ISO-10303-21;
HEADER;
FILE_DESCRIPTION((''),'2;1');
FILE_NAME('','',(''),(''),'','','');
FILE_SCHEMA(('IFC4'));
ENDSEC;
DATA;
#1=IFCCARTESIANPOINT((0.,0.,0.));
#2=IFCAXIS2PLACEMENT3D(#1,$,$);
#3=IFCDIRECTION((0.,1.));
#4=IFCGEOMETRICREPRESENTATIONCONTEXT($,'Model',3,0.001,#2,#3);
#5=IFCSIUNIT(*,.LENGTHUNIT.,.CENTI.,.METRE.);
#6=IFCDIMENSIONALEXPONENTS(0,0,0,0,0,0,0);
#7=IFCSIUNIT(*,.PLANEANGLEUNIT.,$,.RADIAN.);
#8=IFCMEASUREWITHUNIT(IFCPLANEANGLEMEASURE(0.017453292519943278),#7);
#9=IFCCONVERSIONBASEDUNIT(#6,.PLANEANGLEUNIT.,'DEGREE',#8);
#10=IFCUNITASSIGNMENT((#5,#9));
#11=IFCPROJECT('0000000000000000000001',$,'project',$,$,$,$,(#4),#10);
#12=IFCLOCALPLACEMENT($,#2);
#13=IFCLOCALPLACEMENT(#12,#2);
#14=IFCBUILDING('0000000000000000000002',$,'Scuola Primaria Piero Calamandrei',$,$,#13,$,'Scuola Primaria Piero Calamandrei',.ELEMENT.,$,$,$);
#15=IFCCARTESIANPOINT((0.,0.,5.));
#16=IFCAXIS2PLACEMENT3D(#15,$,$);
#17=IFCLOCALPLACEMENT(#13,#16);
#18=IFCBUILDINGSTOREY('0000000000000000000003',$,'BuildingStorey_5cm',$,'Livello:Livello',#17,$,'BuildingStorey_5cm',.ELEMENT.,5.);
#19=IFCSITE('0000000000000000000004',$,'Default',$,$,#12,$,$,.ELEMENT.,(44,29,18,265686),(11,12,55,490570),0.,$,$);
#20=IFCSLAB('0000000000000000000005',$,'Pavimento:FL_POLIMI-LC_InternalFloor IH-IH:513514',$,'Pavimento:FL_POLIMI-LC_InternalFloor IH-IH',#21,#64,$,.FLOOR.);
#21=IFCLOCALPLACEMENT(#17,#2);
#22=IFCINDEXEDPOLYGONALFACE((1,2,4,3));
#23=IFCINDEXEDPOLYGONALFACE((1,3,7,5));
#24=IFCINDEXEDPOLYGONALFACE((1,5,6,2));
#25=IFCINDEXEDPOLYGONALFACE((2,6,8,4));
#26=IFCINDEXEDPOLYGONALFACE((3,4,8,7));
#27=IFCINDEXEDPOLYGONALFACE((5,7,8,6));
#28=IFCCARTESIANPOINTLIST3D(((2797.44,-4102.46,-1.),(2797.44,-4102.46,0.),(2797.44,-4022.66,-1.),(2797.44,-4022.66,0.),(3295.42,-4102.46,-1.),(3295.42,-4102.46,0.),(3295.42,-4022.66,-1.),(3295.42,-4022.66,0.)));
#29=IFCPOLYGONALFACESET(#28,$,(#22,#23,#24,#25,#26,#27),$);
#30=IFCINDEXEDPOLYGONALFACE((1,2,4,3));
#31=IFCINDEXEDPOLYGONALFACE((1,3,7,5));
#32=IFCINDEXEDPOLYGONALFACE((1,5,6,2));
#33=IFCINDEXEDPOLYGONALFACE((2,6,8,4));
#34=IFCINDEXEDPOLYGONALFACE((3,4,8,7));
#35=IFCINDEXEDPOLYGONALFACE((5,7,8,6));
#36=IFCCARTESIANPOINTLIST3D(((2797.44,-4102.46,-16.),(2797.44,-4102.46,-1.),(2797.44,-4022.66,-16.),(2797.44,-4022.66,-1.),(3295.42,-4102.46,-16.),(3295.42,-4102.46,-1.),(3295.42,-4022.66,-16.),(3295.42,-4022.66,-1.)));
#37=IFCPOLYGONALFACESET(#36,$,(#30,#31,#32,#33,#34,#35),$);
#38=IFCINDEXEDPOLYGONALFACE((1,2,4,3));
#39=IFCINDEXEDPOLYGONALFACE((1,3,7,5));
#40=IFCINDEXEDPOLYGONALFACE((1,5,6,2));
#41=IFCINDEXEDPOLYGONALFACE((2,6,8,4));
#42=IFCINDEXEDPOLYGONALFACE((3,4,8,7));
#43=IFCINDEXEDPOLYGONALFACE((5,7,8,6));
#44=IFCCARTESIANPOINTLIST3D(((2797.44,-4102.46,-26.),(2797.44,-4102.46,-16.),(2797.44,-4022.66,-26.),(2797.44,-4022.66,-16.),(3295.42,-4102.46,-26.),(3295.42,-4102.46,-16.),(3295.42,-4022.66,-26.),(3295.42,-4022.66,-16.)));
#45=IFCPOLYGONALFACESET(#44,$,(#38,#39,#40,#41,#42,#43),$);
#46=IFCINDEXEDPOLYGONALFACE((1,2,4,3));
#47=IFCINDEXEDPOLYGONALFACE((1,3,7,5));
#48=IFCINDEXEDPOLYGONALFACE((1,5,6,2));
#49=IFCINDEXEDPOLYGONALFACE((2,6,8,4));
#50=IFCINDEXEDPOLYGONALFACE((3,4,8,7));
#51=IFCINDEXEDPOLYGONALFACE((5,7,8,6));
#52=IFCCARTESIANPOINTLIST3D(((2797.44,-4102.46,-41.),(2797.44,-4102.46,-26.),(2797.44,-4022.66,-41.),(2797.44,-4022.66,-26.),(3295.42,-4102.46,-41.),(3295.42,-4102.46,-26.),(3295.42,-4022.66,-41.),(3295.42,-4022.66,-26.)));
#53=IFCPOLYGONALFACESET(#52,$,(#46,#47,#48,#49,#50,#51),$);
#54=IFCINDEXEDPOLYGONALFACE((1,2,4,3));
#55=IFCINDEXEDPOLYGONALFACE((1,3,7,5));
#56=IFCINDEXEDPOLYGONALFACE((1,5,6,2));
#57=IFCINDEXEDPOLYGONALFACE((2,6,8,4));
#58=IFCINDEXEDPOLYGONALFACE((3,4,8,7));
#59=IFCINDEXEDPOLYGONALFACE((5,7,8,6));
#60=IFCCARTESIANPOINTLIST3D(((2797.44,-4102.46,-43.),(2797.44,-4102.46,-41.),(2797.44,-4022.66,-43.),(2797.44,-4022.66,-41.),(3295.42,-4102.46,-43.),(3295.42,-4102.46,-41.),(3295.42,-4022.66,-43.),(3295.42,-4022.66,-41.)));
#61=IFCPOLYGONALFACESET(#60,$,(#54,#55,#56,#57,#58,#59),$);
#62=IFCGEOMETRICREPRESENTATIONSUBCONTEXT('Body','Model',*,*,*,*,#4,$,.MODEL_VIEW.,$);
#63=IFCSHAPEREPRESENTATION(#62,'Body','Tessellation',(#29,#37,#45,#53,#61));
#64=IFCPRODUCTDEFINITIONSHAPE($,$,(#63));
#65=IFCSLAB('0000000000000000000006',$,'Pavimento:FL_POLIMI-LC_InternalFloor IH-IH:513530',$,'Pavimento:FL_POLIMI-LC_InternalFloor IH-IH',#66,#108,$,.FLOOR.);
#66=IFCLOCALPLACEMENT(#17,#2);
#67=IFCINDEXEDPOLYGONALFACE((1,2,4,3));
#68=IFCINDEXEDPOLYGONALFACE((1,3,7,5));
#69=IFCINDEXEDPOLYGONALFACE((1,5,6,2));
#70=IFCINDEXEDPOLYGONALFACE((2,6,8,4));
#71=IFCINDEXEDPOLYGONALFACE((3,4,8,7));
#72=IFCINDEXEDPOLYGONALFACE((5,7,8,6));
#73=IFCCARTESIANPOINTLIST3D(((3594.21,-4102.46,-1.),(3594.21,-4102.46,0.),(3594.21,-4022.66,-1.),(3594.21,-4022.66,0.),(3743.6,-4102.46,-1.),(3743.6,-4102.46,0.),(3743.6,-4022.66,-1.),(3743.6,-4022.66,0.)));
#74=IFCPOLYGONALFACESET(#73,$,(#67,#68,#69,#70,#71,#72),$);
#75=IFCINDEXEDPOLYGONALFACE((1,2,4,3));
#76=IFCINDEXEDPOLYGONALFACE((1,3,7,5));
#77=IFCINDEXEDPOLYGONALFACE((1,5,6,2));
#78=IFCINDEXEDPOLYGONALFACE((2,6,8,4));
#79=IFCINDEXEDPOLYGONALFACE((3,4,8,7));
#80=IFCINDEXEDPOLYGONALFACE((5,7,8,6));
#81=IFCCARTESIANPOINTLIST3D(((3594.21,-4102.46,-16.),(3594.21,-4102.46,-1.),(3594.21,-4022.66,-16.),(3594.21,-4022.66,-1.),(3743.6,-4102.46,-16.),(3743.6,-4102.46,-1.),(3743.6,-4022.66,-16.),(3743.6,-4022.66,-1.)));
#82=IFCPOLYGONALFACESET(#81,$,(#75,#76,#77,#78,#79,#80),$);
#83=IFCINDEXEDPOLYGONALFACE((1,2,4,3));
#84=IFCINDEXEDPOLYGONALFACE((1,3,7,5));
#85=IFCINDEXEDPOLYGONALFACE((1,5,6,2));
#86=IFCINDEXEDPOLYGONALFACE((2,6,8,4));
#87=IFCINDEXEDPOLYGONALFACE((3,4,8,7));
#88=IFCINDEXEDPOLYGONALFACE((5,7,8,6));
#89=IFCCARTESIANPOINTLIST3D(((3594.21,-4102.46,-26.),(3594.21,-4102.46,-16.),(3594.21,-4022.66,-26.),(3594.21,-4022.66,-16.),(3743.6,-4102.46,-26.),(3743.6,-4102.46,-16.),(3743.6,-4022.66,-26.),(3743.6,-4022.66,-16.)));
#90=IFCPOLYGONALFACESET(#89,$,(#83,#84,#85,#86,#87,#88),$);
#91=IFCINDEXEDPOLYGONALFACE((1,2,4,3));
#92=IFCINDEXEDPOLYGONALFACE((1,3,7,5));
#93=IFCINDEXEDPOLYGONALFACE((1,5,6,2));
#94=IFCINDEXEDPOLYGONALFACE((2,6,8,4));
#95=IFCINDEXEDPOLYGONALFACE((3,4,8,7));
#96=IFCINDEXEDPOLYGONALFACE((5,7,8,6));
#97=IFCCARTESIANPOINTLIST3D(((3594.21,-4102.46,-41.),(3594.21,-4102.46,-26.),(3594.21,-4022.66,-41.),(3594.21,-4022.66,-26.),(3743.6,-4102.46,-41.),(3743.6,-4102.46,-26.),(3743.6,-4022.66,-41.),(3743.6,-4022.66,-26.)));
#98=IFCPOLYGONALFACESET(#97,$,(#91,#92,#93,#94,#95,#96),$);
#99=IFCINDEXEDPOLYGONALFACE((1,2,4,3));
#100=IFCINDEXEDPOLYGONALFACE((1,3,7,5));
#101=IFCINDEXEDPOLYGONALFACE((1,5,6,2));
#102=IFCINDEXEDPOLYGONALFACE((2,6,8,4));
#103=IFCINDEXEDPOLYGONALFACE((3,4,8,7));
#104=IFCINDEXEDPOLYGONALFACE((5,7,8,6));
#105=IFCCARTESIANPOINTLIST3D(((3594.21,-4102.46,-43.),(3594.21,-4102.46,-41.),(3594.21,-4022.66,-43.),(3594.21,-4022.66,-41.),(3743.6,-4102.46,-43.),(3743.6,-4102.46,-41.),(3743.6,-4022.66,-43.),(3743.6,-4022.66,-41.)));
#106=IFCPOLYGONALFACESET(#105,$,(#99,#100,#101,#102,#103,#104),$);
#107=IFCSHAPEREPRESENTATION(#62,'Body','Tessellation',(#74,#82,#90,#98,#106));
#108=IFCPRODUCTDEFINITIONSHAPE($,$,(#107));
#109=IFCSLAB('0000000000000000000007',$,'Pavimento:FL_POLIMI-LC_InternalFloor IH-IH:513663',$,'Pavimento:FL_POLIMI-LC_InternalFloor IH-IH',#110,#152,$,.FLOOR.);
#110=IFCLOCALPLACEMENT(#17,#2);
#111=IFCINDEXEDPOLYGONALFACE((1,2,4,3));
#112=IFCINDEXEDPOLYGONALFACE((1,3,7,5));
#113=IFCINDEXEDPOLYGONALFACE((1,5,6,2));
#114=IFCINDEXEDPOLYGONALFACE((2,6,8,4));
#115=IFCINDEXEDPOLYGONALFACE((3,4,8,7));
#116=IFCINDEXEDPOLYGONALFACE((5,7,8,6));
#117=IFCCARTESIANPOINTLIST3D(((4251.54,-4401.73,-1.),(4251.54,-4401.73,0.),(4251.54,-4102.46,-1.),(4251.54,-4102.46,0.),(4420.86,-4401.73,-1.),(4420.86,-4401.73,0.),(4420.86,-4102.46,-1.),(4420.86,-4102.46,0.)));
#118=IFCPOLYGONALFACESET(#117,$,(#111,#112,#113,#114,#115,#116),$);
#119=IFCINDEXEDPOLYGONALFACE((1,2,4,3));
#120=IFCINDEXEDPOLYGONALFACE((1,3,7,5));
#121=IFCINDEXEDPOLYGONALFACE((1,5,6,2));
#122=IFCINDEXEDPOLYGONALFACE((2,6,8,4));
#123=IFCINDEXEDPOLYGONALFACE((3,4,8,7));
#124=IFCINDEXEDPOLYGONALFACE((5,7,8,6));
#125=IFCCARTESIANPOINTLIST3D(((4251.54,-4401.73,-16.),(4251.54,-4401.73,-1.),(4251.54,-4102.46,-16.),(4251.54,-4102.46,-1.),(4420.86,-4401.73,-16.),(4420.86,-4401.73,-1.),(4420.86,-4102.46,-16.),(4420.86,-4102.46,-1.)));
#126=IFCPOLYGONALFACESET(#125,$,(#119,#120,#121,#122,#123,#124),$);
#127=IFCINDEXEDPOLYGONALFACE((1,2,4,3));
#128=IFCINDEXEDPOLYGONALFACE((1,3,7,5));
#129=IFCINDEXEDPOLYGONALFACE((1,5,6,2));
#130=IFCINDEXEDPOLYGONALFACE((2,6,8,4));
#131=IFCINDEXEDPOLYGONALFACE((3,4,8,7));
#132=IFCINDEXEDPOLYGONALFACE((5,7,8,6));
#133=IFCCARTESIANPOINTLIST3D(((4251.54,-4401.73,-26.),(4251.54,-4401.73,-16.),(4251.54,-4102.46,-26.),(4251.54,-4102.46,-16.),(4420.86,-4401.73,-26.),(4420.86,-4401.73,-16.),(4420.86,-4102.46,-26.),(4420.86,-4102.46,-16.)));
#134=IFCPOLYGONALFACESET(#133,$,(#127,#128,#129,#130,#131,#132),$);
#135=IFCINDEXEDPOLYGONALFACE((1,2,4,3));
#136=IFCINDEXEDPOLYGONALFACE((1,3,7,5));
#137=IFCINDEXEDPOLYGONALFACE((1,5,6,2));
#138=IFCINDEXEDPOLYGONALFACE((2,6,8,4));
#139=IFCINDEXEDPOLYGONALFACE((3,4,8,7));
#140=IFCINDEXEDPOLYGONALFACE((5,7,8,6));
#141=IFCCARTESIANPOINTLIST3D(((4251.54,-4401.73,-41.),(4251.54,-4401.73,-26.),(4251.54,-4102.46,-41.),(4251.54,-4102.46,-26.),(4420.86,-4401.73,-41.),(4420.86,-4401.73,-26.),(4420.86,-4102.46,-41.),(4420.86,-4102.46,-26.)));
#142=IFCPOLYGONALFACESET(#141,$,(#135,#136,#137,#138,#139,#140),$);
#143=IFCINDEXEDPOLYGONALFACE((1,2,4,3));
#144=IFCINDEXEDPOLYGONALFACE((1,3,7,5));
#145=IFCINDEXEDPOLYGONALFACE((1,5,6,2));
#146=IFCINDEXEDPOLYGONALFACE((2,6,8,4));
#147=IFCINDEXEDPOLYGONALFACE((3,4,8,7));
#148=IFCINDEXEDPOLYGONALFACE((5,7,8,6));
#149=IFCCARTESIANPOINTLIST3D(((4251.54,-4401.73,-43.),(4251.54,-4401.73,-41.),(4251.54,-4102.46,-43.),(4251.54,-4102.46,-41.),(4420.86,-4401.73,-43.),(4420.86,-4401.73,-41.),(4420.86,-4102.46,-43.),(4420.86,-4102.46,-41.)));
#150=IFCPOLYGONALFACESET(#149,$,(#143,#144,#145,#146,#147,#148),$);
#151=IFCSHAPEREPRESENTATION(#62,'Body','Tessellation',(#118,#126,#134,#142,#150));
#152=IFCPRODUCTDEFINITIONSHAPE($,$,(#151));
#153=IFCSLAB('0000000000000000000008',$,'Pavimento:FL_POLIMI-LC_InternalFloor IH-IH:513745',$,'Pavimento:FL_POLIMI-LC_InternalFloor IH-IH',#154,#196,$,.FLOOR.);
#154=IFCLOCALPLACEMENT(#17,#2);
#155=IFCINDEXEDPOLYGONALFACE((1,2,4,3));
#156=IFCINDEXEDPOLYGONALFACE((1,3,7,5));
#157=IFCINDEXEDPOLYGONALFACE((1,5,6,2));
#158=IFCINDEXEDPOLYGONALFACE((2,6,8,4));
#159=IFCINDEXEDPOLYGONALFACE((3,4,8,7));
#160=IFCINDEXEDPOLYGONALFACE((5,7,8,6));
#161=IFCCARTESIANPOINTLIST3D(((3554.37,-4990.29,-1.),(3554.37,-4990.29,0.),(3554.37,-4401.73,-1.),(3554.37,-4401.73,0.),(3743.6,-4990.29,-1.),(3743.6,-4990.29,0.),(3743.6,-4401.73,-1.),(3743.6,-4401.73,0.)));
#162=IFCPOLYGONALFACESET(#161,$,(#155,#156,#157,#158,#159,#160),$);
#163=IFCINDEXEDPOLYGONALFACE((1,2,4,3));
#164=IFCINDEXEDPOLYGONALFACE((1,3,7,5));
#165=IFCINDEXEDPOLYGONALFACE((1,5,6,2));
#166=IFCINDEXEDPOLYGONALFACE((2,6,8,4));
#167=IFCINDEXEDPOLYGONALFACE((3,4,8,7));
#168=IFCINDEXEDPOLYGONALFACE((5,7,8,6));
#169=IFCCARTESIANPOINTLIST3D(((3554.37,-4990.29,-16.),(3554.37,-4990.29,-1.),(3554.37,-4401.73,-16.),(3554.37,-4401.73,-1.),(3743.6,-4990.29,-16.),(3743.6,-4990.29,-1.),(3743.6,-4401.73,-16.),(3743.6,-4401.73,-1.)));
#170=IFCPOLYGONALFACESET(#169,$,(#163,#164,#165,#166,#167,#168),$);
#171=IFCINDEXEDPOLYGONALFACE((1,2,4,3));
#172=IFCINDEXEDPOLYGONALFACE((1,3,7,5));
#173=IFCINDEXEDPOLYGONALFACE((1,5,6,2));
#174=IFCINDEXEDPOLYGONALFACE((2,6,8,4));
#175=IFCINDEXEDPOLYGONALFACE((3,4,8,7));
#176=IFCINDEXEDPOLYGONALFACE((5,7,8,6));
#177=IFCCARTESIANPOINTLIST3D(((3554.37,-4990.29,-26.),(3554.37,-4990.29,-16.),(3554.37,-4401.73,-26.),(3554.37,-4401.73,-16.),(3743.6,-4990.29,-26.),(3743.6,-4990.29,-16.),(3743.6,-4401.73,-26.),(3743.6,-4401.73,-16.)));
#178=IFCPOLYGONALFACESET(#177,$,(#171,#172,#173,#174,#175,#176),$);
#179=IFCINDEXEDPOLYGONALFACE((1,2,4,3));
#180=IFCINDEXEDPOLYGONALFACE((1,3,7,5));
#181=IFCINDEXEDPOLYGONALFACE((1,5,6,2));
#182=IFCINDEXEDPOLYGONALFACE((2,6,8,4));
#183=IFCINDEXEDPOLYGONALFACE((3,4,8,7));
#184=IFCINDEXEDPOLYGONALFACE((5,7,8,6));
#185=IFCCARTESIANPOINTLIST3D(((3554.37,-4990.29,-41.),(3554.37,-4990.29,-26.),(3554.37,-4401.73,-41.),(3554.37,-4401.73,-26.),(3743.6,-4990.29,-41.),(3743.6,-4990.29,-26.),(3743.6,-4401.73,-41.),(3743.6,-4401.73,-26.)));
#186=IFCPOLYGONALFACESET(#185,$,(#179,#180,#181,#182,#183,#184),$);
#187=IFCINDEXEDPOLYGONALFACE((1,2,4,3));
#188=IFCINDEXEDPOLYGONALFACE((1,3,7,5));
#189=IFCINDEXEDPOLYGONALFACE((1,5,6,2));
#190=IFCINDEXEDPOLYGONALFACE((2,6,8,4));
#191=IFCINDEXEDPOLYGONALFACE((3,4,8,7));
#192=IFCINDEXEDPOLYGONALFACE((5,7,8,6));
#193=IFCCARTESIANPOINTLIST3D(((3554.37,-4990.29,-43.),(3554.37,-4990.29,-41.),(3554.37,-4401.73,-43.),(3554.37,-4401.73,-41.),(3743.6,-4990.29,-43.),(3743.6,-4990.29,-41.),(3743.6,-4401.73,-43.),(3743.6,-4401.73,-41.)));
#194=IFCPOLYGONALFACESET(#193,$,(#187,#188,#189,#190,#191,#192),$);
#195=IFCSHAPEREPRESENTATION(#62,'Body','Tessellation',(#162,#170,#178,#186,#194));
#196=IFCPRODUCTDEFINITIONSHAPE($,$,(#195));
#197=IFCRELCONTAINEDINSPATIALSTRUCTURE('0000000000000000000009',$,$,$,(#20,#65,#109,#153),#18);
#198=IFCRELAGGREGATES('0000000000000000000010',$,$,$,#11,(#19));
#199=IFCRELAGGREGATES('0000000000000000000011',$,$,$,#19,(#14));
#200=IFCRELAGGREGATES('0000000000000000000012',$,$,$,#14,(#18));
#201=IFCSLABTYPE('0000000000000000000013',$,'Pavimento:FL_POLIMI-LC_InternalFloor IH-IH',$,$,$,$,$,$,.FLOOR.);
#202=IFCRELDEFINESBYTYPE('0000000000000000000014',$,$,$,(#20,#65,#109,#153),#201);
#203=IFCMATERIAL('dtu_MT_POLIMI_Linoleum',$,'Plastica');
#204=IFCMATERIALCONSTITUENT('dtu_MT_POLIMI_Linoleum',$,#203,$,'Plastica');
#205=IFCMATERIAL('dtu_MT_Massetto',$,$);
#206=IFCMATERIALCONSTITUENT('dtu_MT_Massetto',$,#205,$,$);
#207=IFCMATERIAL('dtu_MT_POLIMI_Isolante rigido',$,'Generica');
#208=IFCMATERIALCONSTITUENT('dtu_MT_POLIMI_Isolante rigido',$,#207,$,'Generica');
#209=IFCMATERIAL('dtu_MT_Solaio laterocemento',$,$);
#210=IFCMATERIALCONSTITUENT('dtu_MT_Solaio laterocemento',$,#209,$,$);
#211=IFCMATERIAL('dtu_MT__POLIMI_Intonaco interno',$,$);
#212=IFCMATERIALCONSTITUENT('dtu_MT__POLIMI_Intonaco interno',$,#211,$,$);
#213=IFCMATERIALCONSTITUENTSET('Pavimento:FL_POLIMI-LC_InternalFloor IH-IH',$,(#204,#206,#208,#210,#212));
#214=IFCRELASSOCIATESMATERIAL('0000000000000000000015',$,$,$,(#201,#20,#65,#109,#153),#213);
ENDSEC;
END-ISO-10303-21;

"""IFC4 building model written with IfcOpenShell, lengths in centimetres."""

from ifc_helpers import new_model, entity, si_unit, converted_unit, direction, frame, origin, place, context, subcontext, project, spatial, indexed_curve, outline, extrude, material, constituent, constituent_set, type_object, element, save


model = new_model("IFC4")

# Units and contexts
model_context = context("Model", 3, precision=0.001, world=origin(), true_north=direction((0.0, 1.0)))
body_context = subcontext(model_context, "Body", "Model", "MODEL_VIEW")
ifc_project = project(units=[si_unit("LENGTHUNIT", "METRE", prefix="CENTI"), converted_unit("PLANEANGLEUNIT", "DEGREE", entity("IfcPlaneAngleMeasure", 0.017453292519943278), si_unit("PLANEANGLEUNIT", "RADIAN"), dimensions=[0, 0, 0, 0, 0, 0, 0])], contexts=[model_context])

# Site, building, storey
site_placement = place(None, origin())
site = spatial("IfcSite", under=ifc_project, at=site_placement, Name="Default", CompositionType="ELEMENT", RefLatitude=(44, 29, 18, 265686), RefLongitude=(11, 12, 55, 490570), RefElevation=0.0)
building_placement = place(site_placement, origin())
building = spatial("IfcBuilding", under=site, at=building_placement, Name="Scuola Primaria Piero Calamandrei", LongName="Scuola Primaria Piero Calamandrei", CompositionType="ELEMENT")
storey_placement = place(building_placement, frame((0.0, 0.0, 5.0)))
storey = spatial("IfcBuildingStorey", under=building, at=storey_placement, Name="BuildingStorey_5cm", ObjectType="Livello:Livello", LongName="BuildingStorey_5cm", CompositionType="ELEMENT", Elevation=5.0)

# Slabs
ifc_material_1 = material(Name="dtu_MT_POLIMI_Linoleum", Category="Plastica")
ifc_constituent_1 = constituent(ifc_material_1, Name="dtu_MT_POLIMI_Linoleum", Category="Plastica")
ifc_material_2 = material(Name="dtu_MT_Massetto")
ifc_constituent_2 = constituent(ifc_material_2, Name="dtu_MT_Massetto")
ifc_material_3 = material(Name="dtu_MT_POLIMI_Isolante rigido", Category="Generica")
ifc_constituent_3 = constituent(ifc_material_3, Name="dtu_MT_POLIMI_Isolante rigido", Category="Generica")
ifc_material_4 = material(Name="dtu_MT_Solaio laterocemento")
ifc_constituent_4 = constituent(ifc_material_4, Name="dtu_MT_Solaio laterocemento")
ifc_material_5 = material(Name="dtu_MT__POLIMI_Intonaco interno")
ifc_constituent_5 = constituent(ifc_material_5, Name="dtu_MT__POLIMI_Intonaco interno")
ifc_constituent_set_1 = constituent_set(constituents=[ifc_constituent_1, ifc_constituent_2, ifc_constituent_3, ifc_constituent_4, ifc_constituent_5], Name="Pavimento:FL_POLIMI-LC_InternalFloor IH-IH")
slab_type_1 = type_object("IfcSlabType", Name="Pavimento:FL_POLIMI-LC_InternalFloor IH-IH", PredefinedType="FLOOR", material=ifc_constituent_set_1)
slab_1_placement = place(storey_placement, origin())
element("IfcSlab", 1, at=slab_1_placement, inside=storey, type_object=slab_type_1, material=ifc_constituent_set_1, Name="Pavimento:FL_POLIMI-LC_InternalFloor IH-IH:513514", ObjectType="Pavimento:FL_POLIMI-LC_InternalFloor IH-IH", PredefinedType="FLOOR", context=body_context, shape_type="SweptSolid", body=[
    extrude(outline(indexed_curve([(-39.9, -248.99), (39.9, -248.99), (39.9, 248.99), (-39.9, 248.99), (-39.9, -248.99)], self_intersect=False)), frame((3046.43, -4062.56, -1.0), z_axis=(0.0, 0.0, 1.0), x_axis=(0.0, 1.0, 0.0)), (0.0, 0.0, 1.0), 1.0),
    extrude(outline(indexed_curve([(-39.9, -248.99), (39.9, -248.99), (39.9, 248.99), (-39.9, 248.99), (-39.9, -248.99)], self_intersect=False)), frame((3046.43, -4062.56, -16.0), z_axis=(0.0, 0.0, 1.0), x_axis=(0.0, 1.0, 0.0)), (0.0, 0.0, 1.0), 15.0),
    extrude(outline(indexed_curve([(-39.9, -248.99), (39.9, -248.99), (39.9, 248.99), (-39.9, 248.99), (-39.9, -248.99)], self_intersect=False)), frame((3046.43, -4062.56, -26.0), z_axis=(0.0, 0.0, 1.0), x_axis=(0.0, 1.0, 0.0)), (0.0, 0.0, 1.0), 10.0),
    extrude(outline(indexed_curve([(-39.9, -248.99), (39.9, -248.99), (39.9, 248.99), (-39.9, 248.99), (-39.9, -248.99)], self_intersect=False)), frame((3046.43, -4062.56, -41.0), z_axis=(0.0, 0.0, 1.0), x_axis=(0.0, 1.0, 0.0)), (0.0, 0.0, 1.0), 15.0),
    extrude(outline(indexed_curve([(-39.9, -248.99), (39.9, -248.99), (39.9, 248.99), (-39.9, 248.99), (-39.9, -248.99)], self_intersect=False)), frame((3046.43, -4062.56, -43.0), z_axis=(0.0, 0.0, 1.0), x_axis=(0.0, 1.0, 0.0)), (0.0, 0.0, 1.0), 2.0),
])
slab_2_placement = place(storey_placement, origin())
element("IfcSlab", 2, at=slab_2_placement, inside=storey, type_object=slab_type_1, material=ifc_constituent_set_1, Name="Pavimento:FL_POLIMI-LC_InternalFloor IH-IH:513530", ObjectType="Pavimento:FL_POLIMI-LC_InternalFloor IH-IH", PredefinedType="FLOOR", context=body_context, shape_type="SweptSolid", body=[
    extrude(outline(indexed_curve([(-39.9, -74.7), (39.9, -74.7), (39.9, 74.7), (-39.9, 74.7), (-39.9, -74.7)], self_intersect=False)), frame((3668.9, -4062.56, -1.0), z_axis=(0.0, 0.0, 1.0), x_axis=(0.0, 1.0, 0.0)), (0.0, 0.0, 1.0), 1.0),
    extrude(outline(indexed_curve([(-39.9, -74.7), (39.9, -74.7), (39.9, 74.7), (-39.9, 74.7), (-39.9, -74.7)], self_intersect=False)), frame((3668.9, -4062.56, -16.0), z_axis=(0.0, 0.0, 1.0), x_axis=(0.0, 1.0, 0.0)), (0.0, 0.0, 1.0), 15.0),
    extrude(outline(indexed_curve([(-39.9, -74.7), (39.9, -74.7), (39.9, 74.7), (-39.9, 74.7), (-39.9, -74.7)], self_intersect=False)), frame((3668.9, -4062.56, -26.0), z_axis=(0.0, 0.0, 1.0), x_axis=(0.0, 1.0, 0.0)), (0.0, 0.0, 1.0), 10.0),
    extrude(outline(indexed_curve([(-39.9, -74.7), (39.9, -74.7), (39.9, 74.7), (-39.9, 74.7), (-39.9, -74.7)], self_intersect=False)), frame((3668.9, -4062.56, -41.0), z_axis=(0.0, 0.0, 1.0), x_axis=(0.0, 1.0, 0.0)), (0.0, 0.0, 1.0), 15.0),
    extrude(outline(indexed_curve([(-39.9, -74.7), (39.9, -74.7), (39.9, 74.7), (-39.9, 74.7), (-39.9, -74.7)], self_intersect=False)), frame((3668.9, -4062.56, -43.0), z_axis=(0.0, 0.0, 1.0), x_axis=(0.0, 1.0, 0.0)), (0.0, 0.0, 1.0), 2.0),
])
slab_3_placement = place(storey_placement, origin())
element("IfcSlab", 3, at=slab_3_placement, inside=storey, type_object=slab_type_1, material=ifc_constituent_set_1, Name="Pavimento:FL_POLIMI-LC_InternalFloor IH-IH:513663", ObjectType="Pavimento:FL_POLIMI-LC_InternalFloor IH-IH", PredefinedType="FLOOR", context=body_context, shape_type="SweptSolid", body=[
    extrude(outline(indexed_curve([(-84.66, -149.63), (84.66, -149.63), (84.66, 149.63), (-84.66, 149.63), (-84.66, -149.63)], self_intersect=False)), frame((4336.2, -4252.1, -1.0), z_axis=(0.0, 0.0, 1.0), x_axis=(-1.0, 0.0, 0.0)), (0.0, 0.0, 1.0), 1.0),
    extrude(outline(indexed_curve([(-84.66, -149.63), (84.66, -149.63), (84.66, 149.63), (-84.66, 149.63), (-84.66, -149.63)], self_intersect=False)), frame((4336.2, -4252.1, -16.0), z_axis=(0.0, 0.0, 1.0), x_axis=(-1.0, 0.0, 0.0)), (0.0, 0.0, 1.0), 15.0),
    extrude(outline(indexed_curve([(-84.66, -149.63), (84.66, -149.63), (84.66, 149.63), (-84.66, 149.63), (-84.66, -149.63)], self_intersect=False)), frame((4336.2, -4252.1, -26.0), z_axis=(0.0, 0.0, 1.0), x_axis=(-1.0, 0.0, 0.0)), (0.0, 0.0, 1.0), 10.0),
    extrude(outline(indexed_curve([(-84.66, -149.63), (84.66, -149.63), (84.66, 149.63), (-84.66, 149.63), (-84.66, -149.63)], self_intersect=False)), frame((4336.2, -4252.1, -41.0), z_axis=(0.0, 0.0, 1.0), x_axis=(-1.0, 0.0, 0.0)), (0.0, 0.0, 1.0), 15.0),
    extrude(outline(indexed_curve([(-84.66, -149.63), (84.66, -149.63), (84.66, 149.63), (-84.66, 149.63), (-84.66, -149.63)], self_intersect=False)), frame((4336.2, -4252.1, -43.0), z_axis=(0.0, 0.0, 1.0), x_axis=(-1.0, 0.0, 0.0)), (0.0, 0.0, 1.0), 2.0),
])
slab_4_placement = place(storey_placement, origin())
element("IfcSlab", 4, at=slab_4_placement, inside=storey, type_object=slab_type_1, material=ifc_constituent_set_1, Name="Pavimento:FL_POLIMI-LC_InternalFloor IH-IH:513745", ObjectType="Pavimento:FL_POLIMI-LC_InternalFloor IH-IH", PredefinedType="FLOOR", context=body_context, shape_type="SweptSolid", body=[
    extrude(outline(indexed_curve([(-94.62, -294.28), (94.62, -294.28), (94.62, 294.28), (-94.62, 294.28), (-94.62, -294.28)], self_intersect=False)), frame((3648.99, -4696.01, -1.0), z_axis=(0.0, 0.0, 1.0), x_axis=(-1.0, 0.0, 0.0)), (0.0, 0.0, 1.0), 1.0),
    extrude(outline(indexed_curve([(-94.62, -294.28), (94.62, -294.28), (94.62, 294.28), (-94.62, 294.28), (-94.62, -294.28)], self_intersect=False)), frame((3648.99, -4696.01, -16.0), z_axis=(0.0, 0.0, 1.0), x_axis=(-1.0, 0.0, 0.0)), (0.0, 0.0, 1.0), 15.0),
    extrude(outline(indexed_curve([(-94.62, -294.28), (94.62, -294.28), (94.62, 294.28), (-94.62, 294.28), (-94.62, -294.28)], self_intersect=False)), frame((3648.99, -4696.01, -26.0), z_axis=(0.0, 0.0, 1.0), x_axis=(-1.0, 0.0, 0.0)), (0.0, 0.0, 1.0), 10.0),
    extrude(outline(indexed_curve([(-94.62, -294.28), (94.62, -294.28), (94.62, 294.28), (-94.62, 294.28), (-94.62, -294.28)], self_intersect=False)), frame((3648.99, -4696.01, -41.0), z_axis=(0.0, 0.0, 1.0), x_axis=(-1.0, 0.0, 0.0)), (0.0, 0.0, 1.0), 15.0),
    extrude(outline(indexed_curve([(-94.62, -294.28), (94.62, -294.28), (94.62, 294.28), (-94.62, 294.28), (-94.62, -294.28)], self_intersect=False)), frame((3648.99, -4696.01, -43.0), z_axis=(0.0, 0.0, 1.0), x_axis=(-1.0, 0.0, 0.0)), (0.0, 0.0, 1.0), 2.0),
])

save(model, "model.ifc")
